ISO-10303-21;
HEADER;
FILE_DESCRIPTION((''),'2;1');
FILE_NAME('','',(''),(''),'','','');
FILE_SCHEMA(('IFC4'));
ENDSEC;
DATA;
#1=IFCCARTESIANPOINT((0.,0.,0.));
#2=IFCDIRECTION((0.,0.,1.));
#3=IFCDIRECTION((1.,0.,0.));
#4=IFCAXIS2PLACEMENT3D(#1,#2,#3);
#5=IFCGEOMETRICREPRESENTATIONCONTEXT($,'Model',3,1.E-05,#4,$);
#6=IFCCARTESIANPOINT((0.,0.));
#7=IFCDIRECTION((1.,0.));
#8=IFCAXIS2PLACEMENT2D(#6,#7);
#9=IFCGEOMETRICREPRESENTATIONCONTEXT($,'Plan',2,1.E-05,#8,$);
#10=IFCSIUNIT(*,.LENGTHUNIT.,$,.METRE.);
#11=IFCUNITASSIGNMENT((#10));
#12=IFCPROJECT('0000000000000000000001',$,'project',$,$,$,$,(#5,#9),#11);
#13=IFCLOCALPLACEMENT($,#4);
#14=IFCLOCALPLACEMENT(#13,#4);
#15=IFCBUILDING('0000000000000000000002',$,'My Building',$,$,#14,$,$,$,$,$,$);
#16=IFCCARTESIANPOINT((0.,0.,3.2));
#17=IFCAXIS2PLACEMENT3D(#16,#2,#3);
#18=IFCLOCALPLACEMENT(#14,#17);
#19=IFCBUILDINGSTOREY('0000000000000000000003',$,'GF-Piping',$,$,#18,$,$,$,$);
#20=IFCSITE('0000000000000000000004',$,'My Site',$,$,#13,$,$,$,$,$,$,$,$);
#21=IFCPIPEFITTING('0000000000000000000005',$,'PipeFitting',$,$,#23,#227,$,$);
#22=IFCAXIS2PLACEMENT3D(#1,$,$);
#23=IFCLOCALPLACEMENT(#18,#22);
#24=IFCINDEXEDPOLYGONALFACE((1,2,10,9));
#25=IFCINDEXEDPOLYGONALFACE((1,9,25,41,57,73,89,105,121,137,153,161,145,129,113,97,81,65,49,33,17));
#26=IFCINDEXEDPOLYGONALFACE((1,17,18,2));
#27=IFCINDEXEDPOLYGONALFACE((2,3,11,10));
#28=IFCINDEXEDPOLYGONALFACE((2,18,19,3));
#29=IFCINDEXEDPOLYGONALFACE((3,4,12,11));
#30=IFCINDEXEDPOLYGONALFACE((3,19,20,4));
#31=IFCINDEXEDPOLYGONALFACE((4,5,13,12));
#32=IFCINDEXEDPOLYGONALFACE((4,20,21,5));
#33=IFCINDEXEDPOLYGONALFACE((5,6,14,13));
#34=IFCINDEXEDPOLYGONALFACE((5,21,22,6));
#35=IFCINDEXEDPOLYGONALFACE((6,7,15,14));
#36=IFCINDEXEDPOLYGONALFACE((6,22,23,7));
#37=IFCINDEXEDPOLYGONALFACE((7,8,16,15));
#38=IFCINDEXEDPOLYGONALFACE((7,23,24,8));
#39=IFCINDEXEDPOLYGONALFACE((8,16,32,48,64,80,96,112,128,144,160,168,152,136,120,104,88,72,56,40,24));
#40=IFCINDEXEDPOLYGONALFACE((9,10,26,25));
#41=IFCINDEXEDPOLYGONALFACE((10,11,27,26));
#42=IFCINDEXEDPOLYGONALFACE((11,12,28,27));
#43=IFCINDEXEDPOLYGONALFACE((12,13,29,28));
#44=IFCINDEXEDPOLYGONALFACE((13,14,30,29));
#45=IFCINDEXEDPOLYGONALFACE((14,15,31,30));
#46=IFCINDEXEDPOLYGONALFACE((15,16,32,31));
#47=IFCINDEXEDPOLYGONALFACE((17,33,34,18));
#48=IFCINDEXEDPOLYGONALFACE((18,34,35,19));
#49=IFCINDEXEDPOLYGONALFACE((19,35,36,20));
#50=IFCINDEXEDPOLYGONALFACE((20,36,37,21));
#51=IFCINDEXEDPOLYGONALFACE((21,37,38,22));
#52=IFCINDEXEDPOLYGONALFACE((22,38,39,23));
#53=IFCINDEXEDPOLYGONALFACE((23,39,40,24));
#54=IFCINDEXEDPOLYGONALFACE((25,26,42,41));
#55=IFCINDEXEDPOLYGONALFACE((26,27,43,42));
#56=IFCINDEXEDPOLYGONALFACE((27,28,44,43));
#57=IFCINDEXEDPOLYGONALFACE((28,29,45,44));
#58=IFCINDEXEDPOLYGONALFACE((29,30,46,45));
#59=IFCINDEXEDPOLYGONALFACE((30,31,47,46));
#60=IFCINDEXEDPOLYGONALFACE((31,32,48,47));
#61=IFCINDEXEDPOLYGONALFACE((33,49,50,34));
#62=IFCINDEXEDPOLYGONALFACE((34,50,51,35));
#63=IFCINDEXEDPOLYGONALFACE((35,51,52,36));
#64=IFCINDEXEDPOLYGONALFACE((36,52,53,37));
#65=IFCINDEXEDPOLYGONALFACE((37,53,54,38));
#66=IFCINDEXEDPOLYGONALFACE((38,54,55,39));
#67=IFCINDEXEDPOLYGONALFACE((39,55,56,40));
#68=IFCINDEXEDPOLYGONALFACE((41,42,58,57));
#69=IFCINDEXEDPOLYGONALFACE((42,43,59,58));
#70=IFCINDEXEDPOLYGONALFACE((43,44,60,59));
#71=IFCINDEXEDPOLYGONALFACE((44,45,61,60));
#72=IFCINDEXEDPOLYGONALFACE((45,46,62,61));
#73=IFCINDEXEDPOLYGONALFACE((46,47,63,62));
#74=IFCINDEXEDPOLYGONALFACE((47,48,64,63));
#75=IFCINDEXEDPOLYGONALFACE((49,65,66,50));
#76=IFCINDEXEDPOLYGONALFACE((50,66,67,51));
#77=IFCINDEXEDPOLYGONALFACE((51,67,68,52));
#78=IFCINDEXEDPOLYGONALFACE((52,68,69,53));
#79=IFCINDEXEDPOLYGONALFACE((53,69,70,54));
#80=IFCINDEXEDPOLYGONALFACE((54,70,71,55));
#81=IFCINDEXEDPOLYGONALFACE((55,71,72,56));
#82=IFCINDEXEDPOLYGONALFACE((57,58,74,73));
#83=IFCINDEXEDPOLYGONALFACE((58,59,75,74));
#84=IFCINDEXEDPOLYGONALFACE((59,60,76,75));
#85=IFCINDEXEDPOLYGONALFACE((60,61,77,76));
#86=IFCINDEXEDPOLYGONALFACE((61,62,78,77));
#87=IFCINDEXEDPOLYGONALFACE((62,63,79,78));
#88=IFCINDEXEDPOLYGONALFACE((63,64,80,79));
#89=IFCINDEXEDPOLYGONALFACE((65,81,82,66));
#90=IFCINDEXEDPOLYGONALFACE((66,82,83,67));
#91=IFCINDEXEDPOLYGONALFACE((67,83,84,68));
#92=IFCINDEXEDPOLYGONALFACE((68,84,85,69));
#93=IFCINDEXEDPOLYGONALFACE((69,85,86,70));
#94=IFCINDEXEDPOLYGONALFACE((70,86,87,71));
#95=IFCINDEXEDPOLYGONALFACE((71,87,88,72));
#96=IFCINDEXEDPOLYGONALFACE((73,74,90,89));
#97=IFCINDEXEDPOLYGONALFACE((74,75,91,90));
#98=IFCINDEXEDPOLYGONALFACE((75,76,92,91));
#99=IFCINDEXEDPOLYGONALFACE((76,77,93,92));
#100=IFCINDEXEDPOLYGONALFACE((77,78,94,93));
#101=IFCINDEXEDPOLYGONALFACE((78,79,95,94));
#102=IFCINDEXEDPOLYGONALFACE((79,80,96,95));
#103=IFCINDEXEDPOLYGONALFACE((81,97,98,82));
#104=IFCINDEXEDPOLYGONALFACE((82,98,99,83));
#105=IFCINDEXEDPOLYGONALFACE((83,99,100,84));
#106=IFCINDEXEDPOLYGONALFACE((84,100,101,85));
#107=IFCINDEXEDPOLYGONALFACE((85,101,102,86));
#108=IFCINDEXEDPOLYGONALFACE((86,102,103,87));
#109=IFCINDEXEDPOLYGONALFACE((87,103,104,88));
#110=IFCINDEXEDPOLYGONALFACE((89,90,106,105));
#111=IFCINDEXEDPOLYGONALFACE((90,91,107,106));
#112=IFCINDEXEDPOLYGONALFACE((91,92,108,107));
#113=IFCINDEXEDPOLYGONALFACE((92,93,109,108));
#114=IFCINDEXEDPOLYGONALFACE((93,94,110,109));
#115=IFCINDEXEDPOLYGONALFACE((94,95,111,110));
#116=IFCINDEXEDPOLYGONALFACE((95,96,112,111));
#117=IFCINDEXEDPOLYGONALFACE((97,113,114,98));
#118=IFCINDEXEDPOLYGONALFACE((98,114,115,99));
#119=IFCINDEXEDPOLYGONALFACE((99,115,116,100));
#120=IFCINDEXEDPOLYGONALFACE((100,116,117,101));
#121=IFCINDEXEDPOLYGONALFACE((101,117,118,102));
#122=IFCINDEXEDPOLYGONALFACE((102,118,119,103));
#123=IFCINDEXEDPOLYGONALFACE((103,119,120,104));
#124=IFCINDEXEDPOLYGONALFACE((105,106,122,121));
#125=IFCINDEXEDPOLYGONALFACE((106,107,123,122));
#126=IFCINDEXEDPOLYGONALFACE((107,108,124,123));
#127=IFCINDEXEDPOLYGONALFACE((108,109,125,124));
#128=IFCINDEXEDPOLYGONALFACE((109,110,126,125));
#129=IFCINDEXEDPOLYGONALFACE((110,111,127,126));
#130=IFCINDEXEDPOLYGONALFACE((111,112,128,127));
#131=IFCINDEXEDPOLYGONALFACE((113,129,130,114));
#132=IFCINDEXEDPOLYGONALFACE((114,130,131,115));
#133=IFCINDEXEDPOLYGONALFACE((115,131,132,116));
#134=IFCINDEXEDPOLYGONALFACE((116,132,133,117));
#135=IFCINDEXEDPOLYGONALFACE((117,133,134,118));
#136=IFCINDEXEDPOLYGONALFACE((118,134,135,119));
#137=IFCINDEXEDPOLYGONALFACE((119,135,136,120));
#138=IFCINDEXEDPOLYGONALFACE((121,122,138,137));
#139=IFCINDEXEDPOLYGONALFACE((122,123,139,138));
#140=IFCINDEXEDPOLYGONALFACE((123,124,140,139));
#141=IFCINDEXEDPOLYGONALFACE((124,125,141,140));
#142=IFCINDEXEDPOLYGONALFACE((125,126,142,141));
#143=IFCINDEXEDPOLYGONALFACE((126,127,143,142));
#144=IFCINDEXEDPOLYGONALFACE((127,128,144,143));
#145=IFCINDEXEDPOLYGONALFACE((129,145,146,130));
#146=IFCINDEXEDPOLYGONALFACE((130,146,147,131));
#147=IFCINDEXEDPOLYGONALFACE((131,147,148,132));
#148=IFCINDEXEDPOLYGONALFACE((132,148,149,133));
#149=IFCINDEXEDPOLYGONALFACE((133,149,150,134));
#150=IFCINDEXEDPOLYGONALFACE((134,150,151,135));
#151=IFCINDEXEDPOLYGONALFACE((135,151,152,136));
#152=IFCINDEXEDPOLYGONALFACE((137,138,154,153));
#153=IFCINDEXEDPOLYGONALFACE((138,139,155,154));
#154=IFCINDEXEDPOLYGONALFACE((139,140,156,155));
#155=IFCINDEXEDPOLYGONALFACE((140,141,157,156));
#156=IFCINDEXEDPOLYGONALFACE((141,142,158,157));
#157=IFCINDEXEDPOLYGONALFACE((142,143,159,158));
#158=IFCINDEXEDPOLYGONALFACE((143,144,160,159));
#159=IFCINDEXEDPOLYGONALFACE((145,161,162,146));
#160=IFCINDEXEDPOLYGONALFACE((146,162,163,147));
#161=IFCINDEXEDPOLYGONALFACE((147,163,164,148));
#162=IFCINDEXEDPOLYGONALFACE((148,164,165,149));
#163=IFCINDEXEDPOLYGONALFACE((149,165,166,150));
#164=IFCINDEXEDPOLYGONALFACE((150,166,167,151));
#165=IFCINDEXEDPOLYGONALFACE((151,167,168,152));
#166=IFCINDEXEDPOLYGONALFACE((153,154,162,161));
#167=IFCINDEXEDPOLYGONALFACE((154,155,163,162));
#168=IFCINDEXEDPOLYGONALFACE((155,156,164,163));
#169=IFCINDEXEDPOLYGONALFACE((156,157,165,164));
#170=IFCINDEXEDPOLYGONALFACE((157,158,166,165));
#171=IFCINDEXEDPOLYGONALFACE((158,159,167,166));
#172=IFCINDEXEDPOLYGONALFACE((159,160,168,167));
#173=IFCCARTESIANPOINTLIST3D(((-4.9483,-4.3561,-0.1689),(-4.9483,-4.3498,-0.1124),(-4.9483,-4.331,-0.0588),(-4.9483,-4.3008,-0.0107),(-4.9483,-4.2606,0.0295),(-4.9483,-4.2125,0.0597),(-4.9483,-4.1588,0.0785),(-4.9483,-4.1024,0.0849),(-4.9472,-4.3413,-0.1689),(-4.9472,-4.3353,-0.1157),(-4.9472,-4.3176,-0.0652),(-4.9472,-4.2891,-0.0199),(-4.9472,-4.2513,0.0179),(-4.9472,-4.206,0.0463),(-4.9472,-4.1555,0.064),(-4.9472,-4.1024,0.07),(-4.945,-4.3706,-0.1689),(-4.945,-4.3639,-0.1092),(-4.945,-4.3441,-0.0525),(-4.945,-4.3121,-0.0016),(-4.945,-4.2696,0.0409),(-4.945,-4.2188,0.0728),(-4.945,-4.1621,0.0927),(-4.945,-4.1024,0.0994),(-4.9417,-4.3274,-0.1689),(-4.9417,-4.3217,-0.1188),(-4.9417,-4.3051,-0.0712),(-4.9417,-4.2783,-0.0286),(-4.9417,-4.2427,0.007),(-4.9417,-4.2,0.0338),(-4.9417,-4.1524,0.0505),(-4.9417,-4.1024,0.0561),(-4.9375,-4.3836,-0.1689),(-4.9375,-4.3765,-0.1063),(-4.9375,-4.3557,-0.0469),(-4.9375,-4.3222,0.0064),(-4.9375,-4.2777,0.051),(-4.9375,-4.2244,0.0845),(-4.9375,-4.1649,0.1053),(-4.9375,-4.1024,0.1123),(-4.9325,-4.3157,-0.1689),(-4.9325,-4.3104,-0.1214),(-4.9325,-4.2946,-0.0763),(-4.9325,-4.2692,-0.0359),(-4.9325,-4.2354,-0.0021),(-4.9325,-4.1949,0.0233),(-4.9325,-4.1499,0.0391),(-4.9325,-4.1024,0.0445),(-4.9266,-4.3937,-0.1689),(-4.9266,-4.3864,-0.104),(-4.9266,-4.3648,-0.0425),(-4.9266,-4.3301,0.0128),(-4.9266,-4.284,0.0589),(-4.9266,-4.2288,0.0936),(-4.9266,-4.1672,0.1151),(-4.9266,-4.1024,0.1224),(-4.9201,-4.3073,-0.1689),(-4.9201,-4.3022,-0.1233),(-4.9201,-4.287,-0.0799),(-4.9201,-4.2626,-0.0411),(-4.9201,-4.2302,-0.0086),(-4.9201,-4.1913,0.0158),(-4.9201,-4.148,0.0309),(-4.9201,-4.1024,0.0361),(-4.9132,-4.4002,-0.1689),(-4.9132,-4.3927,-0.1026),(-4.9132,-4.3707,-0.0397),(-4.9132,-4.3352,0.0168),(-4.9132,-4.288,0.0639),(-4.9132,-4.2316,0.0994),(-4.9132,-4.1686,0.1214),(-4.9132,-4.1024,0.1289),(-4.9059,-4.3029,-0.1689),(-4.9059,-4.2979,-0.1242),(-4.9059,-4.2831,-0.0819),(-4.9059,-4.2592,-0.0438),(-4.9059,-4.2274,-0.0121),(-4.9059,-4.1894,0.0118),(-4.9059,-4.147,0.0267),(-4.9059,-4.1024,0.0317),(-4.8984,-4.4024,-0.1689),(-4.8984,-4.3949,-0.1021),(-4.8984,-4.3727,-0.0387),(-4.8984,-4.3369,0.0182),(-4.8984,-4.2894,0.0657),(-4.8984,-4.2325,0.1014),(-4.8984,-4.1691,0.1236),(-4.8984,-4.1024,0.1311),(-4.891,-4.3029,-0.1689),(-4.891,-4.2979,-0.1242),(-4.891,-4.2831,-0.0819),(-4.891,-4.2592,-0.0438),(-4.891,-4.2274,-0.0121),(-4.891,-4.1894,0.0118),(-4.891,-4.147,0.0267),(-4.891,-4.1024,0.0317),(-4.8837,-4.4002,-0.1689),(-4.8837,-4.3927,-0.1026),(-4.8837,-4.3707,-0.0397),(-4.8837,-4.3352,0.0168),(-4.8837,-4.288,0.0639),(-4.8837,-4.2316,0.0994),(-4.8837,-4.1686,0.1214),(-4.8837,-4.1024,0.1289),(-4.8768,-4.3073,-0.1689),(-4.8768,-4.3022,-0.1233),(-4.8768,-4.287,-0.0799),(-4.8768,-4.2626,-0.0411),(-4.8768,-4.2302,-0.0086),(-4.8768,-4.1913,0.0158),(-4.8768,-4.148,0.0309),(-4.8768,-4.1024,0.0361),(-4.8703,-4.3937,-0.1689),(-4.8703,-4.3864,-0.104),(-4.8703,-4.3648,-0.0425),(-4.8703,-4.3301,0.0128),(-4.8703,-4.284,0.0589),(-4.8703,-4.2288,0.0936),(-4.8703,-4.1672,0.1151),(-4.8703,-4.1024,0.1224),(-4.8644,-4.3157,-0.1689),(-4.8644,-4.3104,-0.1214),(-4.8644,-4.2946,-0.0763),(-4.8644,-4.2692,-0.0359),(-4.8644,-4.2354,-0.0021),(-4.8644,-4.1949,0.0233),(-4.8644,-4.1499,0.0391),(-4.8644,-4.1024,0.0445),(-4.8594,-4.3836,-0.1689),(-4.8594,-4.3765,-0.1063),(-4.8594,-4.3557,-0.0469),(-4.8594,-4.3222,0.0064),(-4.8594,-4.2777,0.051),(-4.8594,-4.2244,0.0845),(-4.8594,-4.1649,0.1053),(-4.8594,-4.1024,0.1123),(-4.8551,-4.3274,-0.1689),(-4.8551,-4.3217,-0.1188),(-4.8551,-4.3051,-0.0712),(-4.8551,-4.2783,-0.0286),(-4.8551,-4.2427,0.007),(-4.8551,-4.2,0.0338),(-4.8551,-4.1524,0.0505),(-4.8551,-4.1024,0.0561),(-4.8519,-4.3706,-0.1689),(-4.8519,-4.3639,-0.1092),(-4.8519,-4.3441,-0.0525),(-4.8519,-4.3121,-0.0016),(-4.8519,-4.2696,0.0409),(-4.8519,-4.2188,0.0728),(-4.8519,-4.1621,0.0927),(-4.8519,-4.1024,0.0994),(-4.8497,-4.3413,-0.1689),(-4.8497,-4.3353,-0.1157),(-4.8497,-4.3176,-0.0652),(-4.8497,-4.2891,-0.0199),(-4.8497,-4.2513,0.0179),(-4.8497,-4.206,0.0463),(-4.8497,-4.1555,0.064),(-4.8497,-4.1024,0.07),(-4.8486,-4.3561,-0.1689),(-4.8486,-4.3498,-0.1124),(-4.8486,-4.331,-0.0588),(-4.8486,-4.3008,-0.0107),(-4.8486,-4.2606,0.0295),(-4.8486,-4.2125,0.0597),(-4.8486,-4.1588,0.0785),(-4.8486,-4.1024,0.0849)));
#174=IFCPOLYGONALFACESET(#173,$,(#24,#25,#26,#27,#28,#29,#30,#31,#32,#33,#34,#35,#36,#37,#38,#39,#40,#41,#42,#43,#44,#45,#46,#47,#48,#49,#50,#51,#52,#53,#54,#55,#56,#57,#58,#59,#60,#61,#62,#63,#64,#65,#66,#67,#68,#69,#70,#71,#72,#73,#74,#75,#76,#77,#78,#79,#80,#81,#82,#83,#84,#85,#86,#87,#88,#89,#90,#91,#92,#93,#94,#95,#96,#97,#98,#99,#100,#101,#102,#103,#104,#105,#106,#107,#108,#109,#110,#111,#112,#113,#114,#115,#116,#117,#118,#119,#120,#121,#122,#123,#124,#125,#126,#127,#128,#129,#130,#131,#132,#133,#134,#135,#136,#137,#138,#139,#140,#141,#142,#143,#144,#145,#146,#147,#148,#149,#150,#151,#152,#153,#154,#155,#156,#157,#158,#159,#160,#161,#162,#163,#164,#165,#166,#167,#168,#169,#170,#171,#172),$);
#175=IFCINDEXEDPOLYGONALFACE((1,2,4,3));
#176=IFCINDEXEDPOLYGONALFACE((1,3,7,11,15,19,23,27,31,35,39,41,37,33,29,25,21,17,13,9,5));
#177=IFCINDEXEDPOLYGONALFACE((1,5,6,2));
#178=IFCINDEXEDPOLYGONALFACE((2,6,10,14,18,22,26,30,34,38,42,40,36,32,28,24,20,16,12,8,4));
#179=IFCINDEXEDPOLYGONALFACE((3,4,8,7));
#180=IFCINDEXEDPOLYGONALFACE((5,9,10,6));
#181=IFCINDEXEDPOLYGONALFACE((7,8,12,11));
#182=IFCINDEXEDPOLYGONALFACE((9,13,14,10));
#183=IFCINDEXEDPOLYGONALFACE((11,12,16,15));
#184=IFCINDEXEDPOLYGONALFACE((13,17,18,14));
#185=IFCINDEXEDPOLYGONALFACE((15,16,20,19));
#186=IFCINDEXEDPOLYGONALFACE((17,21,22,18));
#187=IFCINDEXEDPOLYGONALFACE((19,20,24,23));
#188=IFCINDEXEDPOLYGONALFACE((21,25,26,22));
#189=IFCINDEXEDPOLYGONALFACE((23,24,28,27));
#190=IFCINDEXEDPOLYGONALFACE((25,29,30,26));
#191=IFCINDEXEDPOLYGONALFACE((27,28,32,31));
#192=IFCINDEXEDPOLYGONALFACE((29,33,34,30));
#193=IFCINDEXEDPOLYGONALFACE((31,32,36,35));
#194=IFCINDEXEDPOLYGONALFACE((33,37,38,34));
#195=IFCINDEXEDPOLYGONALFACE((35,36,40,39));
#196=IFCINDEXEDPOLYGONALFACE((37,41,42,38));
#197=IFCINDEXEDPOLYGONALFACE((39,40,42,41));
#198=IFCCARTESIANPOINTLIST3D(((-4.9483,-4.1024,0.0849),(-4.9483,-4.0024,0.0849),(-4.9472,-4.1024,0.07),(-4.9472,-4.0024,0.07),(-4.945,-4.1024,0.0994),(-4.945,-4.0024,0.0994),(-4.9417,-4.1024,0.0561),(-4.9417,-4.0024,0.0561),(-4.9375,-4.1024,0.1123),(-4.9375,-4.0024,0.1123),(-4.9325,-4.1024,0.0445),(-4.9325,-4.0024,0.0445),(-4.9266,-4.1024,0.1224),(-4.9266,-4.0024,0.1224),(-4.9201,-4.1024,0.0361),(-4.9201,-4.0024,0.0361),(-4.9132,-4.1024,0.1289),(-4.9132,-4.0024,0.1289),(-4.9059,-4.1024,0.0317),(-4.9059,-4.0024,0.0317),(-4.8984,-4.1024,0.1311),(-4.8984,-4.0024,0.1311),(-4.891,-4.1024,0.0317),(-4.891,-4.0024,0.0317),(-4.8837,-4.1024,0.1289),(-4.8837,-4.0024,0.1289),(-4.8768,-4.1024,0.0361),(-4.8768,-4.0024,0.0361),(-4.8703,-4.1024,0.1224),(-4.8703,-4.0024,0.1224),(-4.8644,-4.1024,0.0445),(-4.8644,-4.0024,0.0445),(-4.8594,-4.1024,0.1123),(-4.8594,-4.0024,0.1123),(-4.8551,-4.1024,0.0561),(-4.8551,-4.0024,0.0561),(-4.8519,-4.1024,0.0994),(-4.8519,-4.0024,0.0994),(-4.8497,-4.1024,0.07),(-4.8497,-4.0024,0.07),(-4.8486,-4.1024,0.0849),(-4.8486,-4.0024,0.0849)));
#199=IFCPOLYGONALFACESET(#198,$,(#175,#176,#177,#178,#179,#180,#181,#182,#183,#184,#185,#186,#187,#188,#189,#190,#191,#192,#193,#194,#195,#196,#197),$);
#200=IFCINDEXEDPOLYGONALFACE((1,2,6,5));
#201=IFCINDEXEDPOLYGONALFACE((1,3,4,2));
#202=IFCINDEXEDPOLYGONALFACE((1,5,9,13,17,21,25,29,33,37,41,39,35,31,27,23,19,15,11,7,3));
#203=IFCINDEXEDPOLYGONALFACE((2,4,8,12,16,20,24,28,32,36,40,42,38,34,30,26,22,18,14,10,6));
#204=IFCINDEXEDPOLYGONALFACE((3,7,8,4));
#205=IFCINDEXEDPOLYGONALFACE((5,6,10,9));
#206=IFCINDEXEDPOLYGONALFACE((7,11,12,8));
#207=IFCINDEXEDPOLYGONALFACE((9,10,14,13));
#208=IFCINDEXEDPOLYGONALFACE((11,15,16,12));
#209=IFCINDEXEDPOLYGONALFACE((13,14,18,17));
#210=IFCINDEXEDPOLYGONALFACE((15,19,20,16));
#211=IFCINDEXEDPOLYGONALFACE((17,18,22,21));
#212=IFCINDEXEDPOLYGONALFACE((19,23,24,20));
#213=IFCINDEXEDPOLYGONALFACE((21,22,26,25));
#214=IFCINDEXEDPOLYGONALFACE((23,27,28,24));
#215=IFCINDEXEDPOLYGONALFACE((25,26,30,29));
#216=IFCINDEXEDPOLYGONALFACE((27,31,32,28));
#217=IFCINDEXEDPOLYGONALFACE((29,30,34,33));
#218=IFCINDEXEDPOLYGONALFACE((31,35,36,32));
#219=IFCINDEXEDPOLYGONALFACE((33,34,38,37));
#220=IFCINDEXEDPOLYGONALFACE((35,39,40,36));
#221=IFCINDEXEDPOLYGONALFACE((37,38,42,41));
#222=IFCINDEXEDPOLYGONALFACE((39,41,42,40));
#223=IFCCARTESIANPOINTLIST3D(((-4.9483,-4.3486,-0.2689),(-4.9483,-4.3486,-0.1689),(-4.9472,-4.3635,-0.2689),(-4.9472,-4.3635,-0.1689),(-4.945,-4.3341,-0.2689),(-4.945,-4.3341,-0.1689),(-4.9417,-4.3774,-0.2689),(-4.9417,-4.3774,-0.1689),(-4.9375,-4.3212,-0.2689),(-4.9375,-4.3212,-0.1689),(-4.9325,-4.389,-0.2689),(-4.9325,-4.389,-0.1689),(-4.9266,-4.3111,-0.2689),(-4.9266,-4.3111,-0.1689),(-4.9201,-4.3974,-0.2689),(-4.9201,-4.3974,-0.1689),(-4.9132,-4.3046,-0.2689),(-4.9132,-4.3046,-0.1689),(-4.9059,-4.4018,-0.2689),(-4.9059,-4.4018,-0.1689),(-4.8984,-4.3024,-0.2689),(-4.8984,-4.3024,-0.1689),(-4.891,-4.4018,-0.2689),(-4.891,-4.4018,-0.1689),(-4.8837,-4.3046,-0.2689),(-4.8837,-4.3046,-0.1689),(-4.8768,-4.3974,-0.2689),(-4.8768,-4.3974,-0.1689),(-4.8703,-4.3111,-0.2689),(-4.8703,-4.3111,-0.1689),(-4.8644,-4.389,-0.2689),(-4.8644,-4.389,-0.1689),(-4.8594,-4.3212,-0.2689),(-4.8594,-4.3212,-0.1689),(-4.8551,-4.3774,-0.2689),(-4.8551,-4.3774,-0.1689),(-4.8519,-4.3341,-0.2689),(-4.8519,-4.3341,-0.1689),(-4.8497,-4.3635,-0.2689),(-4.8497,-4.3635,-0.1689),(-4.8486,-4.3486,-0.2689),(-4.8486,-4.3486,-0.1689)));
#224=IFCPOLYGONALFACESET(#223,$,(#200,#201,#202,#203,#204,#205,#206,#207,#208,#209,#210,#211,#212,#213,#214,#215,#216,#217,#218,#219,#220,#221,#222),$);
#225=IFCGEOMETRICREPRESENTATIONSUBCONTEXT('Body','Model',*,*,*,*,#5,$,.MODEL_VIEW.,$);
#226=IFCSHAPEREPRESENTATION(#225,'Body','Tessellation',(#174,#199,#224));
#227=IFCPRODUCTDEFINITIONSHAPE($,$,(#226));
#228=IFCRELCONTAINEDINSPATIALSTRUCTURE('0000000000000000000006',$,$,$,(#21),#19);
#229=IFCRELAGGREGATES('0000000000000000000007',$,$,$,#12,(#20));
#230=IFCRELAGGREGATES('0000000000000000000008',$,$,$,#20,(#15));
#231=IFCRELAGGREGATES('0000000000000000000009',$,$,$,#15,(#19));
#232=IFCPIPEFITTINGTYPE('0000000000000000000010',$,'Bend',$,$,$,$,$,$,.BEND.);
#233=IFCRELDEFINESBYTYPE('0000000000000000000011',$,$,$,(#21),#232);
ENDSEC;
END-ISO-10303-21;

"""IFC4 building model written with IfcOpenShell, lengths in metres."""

from ifc_helpers import new_model, entity, si_unit, frame, origin_with_axes, origin_2d_with_axis, place, context, subcontext, project, spatial, circle, extrude, source, transform, mapped, type_object, type_shapes, element, save


model = new_model("IFC4")

# Units and contexts
model_context = context("Model", 3, precision=1e-05, world=origin_with_axes())
plan_context = context("Plan", 2, precision=1e-05, world=origin_2d_with_axis())
body_context = subcontext(model_context, "Body", "Model", "MODEL_VIEW")
ifc_project = project(units=[si_unit("LENGTHUNIT", "METRE")], contexts=[model_context, plan_context])

# Site, building, storey
site_placement = place(None, origin_with_axes())
site = spatial("IfcSite", under=ifc_project, at=site_placement, Name="My Site")
building_placement = place(site_placement, origin_with_axes())
building = spatial("IfcBuilding", under=site, at=building_placement, Name="My Building")
storey_placement = place(building_placement, frame((0.0, 0.0, 3.2), z_axis=(0.0, 0.0, 1.0), x_axis=(1.0, 0.0, 0.0)))
storey = spatial("IfcBuildingStorey", under=building, at=storey_placement, Name="GF-Piping")

# Pipe fitting
pipe_fitting_type = type_object("IfcPipeFittingType", Name="Bend", PredefinedType="BEND")
shared_shape = source(origin_with_axes(), body_context, "Body", "SolidModel", [
    entity("IfcSweptDiskSolid", entity("IfcIndexedPolyCurve", entity("IfcCartesianPointList3D", [[0.0, 0.0, 0.1], [-0.0732, 0.0, 0.2768], [-0.25, 0.0, 0.35]]), [entity("IfcArcIndex", [1, 2, 3])]), 0.05),
    extrude(circle(Radius=0.05), origin_with_axes(), (0.0, 0.0, 1.0), 0.1),
    extrude(circle(Radius=0.05), frame((-0.25, 0.0, 0.35), z_axis=(-1.0, 0.0, 0.0), x_axis=(0.0, 0.0, -1.0)), (0.0, 0.0, 1.0), 0.1),
])
type_shapes(pipe_fitting_type, [shared_shape])
for number, where, z_axis, x_axis, name in (
    (1, (-4.8984, -4.0024, 0.0811), (0.0, -1.0, 0.0), (0.0, 0.0, 1.0), "PipeFitting"),
):
    element("IfcPipeFitting", number, at=place(storey_placement, frame(where, z_axis=z_axis, x_axis=x_axis)), inside=storey, type_object=pipe_fitting_type, Name=name, context=body_context, shape_type="MappedRepresentation", body=[
        mapped(shared_shape, transform((0.0, 0.0, 0.0), x_axis=(1.0, 0.0, 0.0), y_axis=(0.0, 1.0, 0.0), z_axis=(0.0, 0.0, 1.0), scale=1.0)),
    ])

save(model, "model.ifc")
